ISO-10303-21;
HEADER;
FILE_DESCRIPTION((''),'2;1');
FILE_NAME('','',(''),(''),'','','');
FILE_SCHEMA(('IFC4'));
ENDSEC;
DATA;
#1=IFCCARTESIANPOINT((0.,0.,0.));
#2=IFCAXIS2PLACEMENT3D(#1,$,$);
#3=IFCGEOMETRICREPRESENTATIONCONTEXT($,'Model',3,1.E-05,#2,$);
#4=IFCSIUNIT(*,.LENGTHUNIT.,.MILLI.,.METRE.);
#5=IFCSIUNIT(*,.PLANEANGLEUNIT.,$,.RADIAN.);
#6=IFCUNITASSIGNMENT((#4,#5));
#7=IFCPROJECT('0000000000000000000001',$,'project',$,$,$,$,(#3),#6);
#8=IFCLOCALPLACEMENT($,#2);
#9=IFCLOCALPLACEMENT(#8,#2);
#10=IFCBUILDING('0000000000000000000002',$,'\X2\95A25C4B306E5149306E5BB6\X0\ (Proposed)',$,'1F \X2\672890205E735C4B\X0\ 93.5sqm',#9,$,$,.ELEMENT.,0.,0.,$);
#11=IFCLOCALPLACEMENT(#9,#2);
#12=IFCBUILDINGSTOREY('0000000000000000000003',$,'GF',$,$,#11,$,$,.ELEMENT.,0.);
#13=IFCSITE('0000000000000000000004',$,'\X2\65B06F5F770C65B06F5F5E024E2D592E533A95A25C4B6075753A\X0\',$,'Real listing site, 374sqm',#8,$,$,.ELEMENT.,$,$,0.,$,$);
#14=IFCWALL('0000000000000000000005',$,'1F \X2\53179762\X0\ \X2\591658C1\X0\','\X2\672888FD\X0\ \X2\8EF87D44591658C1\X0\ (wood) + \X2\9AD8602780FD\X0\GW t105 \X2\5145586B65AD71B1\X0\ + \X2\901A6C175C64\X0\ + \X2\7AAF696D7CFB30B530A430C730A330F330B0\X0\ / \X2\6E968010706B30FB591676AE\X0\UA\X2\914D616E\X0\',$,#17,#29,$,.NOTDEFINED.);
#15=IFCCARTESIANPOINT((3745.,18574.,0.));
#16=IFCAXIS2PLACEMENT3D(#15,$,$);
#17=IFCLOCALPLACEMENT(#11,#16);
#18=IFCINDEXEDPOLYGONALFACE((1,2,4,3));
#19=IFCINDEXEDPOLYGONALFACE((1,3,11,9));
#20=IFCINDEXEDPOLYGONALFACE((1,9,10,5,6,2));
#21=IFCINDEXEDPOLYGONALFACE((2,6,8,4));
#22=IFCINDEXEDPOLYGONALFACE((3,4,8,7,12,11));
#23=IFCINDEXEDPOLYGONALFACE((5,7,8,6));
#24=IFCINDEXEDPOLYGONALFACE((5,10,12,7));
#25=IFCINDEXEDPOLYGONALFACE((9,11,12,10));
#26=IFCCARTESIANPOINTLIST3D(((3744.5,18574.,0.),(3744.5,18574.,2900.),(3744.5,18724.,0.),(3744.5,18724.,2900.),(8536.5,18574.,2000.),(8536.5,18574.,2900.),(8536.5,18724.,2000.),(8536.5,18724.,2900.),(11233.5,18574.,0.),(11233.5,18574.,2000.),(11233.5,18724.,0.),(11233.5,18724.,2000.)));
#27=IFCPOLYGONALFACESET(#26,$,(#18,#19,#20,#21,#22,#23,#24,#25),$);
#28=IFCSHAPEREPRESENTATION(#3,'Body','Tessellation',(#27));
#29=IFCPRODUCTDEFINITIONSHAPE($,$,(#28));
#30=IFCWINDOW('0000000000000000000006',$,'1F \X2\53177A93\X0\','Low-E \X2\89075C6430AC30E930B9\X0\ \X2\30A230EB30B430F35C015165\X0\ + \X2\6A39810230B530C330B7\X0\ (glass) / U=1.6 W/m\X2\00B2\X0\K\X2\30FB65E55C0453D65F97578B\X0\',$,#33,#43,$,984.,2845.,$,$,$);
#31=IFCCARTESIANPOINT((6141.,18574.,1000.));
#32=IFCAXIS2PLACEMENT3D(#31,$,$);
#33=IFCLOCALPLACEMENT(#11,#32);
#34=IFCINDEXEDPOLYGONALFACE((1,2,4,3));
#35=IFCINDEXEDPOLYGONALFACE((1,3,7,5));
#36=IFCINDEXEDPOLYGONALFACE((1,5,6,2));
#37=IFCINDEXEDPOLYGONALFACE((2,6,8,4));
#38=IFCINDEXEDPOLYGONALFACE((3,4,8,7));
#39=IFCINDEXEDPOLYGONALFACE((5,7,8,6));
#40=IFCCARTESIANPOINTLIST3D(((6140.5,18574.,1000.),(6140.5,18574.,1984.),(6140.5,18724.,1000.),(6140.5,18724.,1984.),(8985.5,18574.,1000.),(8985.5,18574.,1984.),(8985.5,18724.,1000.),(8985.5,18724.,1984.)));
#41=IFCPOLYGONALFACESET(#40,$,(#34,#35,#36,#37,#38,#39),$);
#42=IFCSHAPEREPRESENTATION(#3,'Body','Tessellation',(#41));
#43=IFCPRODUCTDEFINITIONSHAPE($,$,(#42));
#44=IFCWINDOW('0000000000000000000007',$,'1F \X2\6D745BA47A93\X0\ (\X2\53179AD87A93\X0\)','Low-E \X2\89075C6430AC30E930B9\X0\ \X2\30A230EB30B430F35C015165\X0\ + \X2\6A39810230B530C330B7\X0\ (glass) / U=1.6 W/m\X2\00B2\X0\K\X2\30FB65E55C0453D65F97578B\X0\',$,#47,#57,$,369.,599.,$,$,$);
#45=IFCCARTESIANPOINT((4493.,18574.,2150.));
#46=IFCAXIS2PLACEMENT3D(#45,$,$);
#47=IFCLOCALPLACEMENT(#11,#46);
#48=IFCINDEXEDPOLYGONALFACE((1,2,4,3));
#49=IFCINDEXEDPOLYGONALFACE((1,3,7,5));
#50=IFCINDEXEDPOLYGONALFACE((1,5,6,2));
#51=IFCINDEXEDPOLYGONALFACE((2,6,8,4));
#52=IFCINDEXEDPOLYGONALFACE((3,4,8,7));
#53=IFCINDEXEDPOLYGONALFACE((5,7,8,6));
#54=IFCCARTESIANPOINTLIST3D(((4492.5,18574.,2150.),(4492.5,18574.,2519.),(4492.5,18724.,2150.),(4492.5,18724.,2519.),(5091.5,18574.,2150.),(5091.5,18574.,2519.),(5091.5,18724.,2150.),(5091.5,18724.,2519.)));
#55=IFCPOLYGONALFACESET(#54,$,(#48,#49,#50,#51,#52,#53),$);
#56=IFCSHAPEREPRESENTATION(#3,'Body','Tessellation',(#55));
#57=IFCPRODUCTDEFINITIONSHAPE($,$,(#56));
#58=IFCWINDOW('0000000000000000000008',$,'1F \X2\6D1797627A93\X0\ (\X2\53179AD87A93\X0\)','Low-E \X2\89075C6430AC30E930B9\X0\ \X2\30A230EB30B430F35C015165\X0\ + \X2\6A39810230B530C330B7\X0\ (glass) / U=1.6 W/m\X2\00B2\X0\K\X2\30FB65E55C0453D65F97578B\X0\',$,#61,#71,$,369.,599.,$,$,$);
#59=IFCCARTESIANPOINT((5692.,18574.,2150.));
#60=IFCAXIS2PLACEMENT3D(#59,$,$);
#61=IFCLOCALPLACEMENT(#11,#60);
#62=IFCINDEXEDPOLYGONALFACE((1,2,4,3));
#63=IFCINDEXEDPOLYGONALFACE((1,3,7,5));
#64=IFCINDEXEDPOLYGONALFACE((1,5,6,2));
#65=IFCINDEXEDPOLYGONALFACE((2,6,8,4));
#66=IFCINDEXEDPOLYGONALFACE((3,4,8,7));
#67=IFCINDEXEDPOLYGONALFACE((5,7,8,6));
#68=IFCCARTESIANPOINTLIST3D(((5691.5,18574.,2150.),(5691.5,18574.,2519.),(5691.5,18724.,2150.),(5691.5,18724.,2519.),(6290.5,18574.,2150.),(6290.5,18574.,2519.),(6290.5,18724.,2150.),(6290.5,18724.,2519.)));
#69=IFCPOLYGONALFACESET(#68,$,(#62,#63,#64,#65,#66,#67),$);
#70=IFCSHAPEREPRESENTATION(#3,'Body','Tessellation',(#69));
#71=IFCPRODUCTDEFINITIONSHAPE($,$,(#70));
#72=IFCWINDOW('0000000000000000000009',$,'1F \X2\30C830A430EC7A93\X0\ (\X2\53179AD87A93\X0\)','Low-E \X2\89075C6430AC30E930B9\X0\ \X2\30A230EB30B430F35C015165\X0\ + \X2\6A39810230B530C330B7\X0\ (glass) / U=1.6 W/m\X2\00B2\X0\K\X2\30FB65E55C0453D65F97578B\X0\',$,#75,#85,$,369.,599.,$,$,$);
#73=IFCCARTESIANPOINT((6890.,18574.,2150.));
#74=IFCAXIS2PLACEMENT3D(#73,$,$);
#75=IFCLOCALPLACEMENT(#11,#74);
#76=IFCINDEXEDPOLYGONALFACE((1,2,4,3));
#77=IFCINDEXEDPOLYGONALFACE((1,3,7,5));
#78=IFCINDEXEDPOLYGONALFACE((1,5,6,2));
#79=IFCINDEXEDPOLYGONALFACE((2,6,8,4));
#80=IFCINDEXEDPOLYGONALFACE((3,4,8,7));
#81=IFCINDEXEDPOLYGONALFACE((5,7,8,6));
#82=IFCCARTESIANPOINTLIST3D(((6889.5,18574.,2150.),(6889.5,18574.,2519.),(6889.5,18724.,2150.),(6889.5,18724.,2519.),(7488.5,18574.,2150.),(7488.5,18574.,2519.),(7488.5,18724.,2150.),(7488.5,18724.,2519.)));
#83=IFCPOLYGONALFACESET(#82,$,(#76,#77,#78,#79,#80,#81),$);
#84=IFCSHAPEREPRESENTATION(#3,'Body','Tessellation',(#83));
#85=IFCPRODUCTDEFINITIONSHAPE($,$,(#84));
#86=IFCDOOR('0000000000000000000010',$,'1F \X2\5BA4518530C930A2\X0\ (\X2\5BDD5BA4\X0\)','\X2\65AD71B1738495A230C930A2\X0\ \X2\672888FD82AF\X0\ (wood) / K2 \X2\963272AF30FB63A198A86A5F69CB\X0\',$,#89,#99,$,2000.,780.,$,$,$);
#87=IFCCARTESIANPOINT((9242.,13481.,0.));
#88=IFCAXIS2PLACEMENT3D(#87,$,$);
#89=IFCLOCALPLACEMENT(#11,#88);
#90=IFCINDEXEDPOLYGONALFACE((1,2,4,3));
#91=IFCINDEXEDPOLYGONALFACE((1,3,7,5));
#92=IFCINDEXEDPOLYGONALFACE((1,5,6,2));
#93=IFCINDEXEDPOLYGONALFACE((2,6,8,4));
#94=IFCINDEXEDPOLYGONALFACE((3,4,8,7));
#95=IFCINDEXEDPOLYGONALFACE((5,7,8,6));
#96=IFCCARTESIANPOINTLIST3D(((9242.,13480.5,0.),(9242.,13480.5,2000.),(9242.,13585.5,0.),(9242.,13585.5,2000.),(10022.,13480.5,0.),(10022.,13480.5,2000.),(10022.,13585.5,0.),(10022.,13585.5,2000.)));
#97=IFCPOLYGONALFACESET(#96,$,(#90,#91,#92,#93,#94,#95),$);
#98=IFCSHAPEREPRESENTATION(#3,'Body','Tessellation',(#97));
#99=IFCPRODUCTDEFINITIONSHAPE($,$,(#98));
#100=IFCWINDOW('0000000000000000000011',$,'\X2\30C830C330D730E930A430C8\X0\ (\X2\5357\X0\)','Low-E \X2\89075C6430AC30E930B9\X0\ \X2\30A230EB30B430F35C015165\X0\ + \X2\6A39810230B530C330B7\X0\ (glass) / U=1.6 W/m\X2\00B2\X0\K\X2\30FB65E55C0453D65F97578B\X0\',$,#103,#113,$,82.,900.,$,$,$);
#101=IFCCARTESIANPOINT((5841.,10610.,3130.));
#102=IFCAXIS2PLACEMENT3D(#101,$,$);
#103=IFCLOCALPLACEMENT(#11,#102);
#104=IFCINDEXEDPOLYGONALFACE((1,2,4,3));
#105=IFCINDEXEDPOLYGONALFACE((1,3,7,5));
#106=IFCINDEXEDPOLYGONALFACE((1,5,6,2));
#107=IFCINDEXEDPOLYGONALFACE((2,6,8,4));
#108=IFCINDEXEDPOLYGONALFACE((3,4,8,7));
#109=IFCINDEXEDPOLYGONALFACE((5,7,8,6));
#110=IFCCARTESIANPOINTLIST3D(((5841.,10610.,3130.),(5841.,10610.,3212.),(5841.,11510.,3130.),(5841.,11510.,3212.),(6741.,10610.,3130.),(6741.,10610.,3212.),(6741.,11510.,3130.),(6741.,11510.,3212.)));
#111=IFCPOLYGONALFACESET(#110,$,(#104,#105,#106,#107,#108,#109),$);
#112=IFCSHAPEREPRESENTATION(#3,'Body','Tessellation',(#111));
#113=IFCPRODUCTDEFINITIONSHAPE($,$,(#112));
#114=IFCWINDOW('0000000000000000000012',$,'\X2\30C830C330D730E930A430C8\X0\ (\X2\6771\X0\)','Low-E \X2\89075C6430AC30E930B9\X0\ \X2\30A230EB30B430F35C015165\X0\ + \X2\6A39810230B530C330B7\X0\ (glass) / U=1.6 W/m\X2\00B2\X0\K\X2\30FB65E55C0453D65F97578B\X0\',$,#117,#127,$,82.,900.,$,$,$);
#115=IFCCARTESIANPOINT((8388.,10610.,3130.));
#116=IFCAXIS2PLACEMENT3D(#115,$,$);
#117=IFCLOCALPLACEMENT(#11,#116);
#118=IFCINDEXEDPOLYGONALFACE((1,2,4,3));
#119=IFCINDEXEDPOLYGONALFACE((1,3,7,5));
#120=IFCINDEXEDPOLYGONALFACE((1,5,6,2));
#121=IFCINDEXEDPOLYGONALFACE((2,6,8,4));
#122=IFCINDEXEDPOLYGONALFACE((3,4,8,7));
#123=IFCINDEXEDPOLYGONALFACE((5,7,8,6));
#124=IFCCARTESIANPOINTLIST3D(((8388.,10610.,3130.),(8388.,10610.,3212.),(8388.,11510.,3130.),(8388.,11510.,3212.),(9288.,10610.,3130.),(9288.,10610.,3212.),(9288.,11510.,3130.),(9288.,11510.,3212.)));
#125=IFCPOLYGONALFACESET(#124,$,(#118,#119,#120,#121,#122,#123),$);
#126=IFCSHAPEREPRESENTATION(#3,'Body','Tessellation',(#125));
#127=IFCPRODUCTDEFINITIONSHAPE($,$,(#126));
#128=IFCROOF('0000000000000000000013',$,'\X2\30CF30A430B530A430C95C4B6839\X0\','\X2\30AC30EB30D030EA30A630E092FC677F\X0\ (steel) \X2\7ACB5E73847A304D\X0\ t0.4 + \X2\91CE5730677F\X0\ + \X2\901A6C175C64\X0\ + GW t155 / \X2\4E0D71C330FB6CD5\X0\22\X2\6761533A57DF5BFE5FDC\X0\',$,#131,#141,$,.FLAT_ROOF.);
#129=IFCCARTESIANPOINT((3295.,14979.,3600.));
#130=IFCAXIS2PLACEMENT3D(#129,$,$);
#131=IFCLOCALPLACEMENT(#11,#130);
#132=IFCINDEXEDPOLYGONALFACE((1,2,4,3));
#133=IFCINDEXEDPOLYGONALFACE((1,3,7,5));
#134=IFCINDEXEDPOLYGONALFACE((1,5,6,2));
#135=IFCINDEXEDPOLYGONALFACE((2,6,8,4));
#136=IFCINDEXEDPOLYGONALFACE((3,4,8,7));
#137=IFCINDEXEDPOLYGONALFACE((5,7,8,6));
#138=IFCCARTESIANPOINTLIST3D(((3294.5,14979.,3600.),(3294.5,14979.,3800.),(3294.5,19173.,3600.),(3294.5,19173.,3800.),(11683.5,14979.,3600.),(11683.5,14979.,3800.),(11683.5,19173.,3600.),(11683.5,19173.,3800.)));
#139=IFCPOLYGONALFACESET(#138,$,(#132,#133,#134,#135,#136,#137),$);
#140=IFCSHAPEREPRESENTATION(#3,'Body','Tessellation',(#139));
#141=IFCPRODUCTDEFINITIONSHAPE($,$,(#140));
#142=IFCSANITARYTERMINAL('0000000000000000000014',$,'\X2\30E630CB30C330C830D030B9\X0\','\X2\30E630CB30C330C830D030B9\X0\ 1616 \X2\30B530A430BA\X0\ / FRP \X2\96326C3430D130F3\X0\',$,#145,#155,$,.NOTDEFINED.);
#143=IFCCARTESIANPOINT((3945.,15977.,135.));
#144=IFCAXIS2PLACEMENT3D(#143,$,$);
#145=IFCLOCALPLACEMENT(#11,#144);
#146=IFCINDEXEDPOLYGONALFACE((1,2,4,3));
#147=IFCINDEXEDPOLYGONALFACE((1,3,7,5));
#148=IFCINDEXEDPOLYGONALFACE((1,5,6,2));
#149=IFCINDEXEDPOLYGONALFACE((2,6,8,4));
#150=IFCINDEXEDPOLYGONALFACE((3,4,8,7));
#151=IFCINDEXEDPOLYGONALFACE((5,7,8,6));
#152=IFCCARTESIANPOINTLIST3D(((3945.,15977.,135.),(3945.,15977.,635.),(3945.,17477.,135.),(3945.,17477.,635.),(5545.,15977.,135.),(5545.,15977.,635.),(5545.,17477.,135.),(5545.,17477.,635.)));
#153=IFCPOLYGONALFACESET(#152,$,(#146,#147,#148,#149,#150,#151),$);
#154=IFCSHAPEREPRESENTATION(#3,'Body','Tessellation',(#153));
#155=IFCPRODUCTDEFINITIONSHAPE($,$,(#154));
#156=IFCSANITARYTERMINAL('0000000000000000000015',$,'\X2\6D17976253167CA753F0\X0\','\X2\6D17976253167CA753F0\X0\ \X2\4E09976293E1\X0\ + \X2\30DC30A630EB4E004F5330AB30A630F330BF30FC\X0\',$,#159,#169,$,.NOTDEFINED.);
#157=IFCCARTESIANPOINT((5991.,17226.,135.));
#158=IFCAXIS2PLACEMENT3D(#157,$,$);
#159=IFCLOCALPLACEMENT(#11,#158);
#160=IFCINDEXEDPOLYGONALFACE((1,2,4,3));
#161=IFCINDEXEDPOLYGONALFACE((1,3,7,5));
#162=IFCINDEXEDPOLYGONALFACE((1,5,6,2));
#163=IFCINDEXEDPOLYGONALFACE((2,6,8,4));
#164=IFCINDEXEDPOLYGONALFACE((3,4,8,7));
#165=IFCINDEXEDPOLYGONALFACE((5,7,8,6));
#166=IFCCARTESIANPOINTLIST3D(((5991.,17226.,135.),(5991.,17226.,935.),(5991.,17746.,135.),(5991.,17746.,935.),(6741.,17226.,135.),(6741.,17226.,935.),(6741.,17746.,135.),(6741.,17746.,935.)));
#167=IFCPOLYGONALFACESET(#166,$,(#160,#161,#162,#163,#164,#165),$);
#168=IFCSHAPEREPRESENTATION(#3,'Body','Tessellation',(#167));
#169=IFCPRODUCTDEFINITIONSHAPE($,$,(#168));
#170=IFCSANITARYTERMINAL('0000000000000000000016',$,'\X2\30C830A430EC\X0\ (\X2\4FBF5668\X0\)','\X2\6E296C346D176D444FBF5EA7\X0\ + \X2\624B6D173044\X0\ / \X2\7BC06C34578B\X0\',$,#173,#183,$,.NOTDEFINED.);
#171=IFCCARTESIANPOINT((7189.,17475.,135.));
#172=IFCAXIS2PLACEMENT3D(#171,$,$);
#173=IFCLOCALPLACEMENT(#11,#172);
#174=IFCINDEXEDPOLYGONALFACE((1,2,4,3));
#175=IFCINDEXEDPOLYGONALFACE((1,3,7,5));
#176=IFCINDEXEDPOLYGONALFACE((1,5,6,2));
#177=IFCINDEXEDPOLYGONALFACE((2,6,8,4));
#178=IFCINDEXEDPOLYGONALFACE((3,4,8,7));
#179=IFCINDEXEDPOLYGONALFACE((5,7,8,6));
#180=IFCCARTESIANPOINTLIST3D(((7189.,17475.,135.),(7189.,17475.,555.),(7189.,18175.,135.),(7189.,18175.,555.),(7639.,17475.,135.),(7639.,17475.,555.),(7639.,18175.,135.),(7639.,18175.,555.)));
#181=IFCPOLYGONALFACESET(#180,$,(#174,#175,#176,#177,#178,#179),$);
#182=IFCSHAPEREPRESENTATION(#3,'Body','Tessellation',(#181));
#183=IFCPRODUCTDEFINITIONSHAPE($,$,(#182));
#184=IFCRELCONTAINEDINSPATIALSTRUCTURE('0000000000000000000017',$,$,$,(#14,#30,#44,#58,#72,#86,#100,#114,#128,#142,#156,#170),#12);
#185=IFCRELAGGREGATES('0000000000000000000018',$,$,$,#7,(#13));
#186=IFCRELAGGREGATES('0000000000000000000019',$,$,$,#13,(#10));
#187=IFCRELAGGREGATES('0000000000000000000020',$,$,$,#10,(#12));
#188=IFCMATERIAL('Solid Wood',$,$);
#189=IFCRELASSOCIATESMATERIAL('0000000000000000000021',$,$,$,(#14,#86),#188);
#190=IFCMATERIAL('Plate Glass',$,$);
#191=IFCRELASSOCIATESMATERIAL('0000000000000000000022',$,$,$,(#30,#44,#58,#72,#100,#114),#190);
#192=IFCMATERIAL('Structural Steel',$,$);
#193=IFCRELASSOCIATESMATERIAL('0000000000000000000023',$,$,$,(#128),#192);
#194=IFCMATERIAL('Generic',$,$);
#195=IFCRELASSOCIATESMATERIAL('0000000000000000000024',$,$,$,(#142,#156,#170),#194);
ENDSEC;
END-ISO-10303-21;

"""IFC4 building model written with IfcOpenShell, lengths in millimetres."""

from ifc_helpers import new_model, si_unit, frame, frame_2d, origin, place, context, project, spatial, rectangle, extrude, material, element, fill, save


model = new_model("IFC4")

# Units and contexts
model_context = context("Model", 3, precision=1e-05, world=origin())
ifc_project = project(units=[si_unit("LENGTHUNIT", "METRE", prefix="MILLI"), si_unit("PLANEANGLEUNIT", "RADIAN")], contexts=[model_context])

# Site, building, storey
site_placement = place(None, origin())
site = spatial("IfcSite", under=ifc_project, at=site_placement, Name="新潟県新潟市中央区関屋恵町", ObjectType="Real listing site, 374sqm", CompositionType="ELEMENT", RefElevation=0.0)
building_placement = place(site_placement, origin())
building = spatial("IfcBuilding", under=site, at=building_placement, Name="関屋の光の家 (Proposed)", ObjectType="1F 木造平屋 93.5sqm", CompositionType="ELEMENT", ElevationOfRefHeight=0.0, ElevationOfTerrain=0.0)
storey_placement = place(building_placement, origin())
storey = spatial("IfcBuildingStorey", under=building, at=storey_placement, Name="GF", CompositionType="ELEMENT", Elevation=0.0)

# Shared definitions
ifc_material_1 = material(Name="Solid Wood")

# Wall, openings, windows
wall_1_placement = place(storey_placement, frame((3745.0, 18574.0, 0.0)))
wall_1 = element("IfcWall", 1, at=wall_1_placement, inside=storey, material=ifc_material_1, Name="1F 北面 外壁", Description="木製 軸組外壁 (wood) + 高性能GW t105 充填断熱 + 通気層 + 窯業系サイディング / 準耐火・外皮UA配慮", PredefinedType="NOTDEFINED", context=model_context, shape_type="SweptSolid", body=[
    extrude(rectangle(XDim=7489.0, YDim=150.0, at=frame_2d((3744.0, 75.0))), frame((3745.0, 18574.0, 0.0)), (0.0, 0.0, 1.0), 2900.0),
])
opening_1_placement = place(storey_placement, frame((6141.0, 18574.0, 1000.0)))
opening_1 = element("IfcOpeningElement", 2, at=opening_1_placement, cuts=wall_1, PredefinedType="NOTDEFINED", context=model_context, shape_type="SweptSolid", body=[
    extrude(rectangle(XDim=2845.0, YDim=150.0, at=frame_2d((1422.0, 75.0))), frame((6141.0, 18574.0, 1000.0)), (0.0, 0.0, 1.0), 984.0),
])
opening_2_placement = place(storey_placement, frame((4493.0, 18574.0, 2150.0)))
opening_2 = element("IfcOpeningElement", 3, at=opening_2_placement, cuts=wall_1, PredefinedType="NOTDEFINED", context=model_context, shape_type="SweptSolid", body=[
    extrude(rectangle(XDim=599.0, YDim=150.0, at=frame_2d((299.0, 75.0))), frame((4493.0, 18574.0, 2150.0)), (0.0, 0.0, 1.0), 369.0),
])
opening_3_placement = place(storey_placement, frame((5692.0, 18574.0, 2150.0)))
opening_3 = element("IfcOpeningElement", 4, at=opening_3_placement, cuts=wall_1, PredefinedType="NOTDEFINED", context=model_context, shape_type="SweptSolid", body=[
    extrude(rectangle(XDim=599.0, YDim=150.0, at=frame_2d((299.0, 75.0))), frame((5692.0, 18574.0, 2150.0)), (0.0, 0.0, 1.0), 369.0),
])
opening_4_placement = place(storey_placement, frame((6890.0, 18574.0, 2150.0)))
opening_4 = element("IfcOpeningElement", 5, at=opening_4_placement, cuts=wall_1, PredefinedType="NOTDEFINED", context=model_context, shape_type="SweptSolid", body=[
    extrude(rectangle(XDim=599.0, YDim=150.0, at=frame_2d((299.0, 75.0))), frame((6890.0, 18574.0, 2150.0)), (0.0, 0.0, 1.0), 369.0),
])
ifc_material_2 = material(Name="Plate Glass")
window_1_placement = place(storey_placement, frame((6141.0, 18574.0, 1000.0)))
window_1 = element("IfcWindow", 6, at=window_1_placement, inside=storey, material=ifc_material_2, Name="1F 北窓", Description="Low-E 複層ガラス アルゴン封入 + 樹脂サッシ (glass) / U=1.6 W/m²K・日射取得型", OverallHeight=984.0, OverallWidth=2845.0, context=model_context, shape_type="SweptSolid", body=[
    extrude(rectangle(XDim=2845.0, YDim=150.0, at=frame_2d((1422.0, 75.0))), frame((6141.0, 18574.0, 1000.0)), (0.0, 0.0, 1.0), 984.0),
])
fill(opening_1, window_1)
window_2_placement = place(storey_placement, frame((4493.0, 18574.0, 2150.0)))
window_2 = element("IfcWindow", 7, at=window_2_placement, inside=storey, material=ifc_material_2, Name="1F 浴室窓 (北高窓)", Description="Low-E 複層ガラス アルゴン封入 + 樹脂サッシ (glass) / U=1.6 W/m²K・日射取得型", OverallHeight=369.0, OverallWidth=599.0, context=model_context, shape_type="SweptSolid", body=[
    extrude(rectangle(XDim=599.0, YDim=150.0, at=frame_2d((299.0, 75.0))), frame((4493.0, 18574.0, 2150.0)), (0.0, 0.0, 1.0), 369.0),
])
fill(opening_2, window_2)
window_3_placement = place(storey_placement, frame((5692.0, 18574.0, 2150.0)))
window_3 = element("IfcWindow", 8, at=window_3_placement, inside=storey, material=ifc_material_2, Name="1F 洗面窓 (北高窓)", Description="Low-E 複層ガラス アルゴン封入 + 樹脂サッシ (glass) / U=1.6 W/m²K・日射取得型", OverallHeight=369.0, OverallWidth=599.0, context=model_context, shape_type="SweptSolid", body=[
    extrude(rectangle(XDim=599.0, YDim=150.0, at=frame_2d((299.0, 75.0))), frame((5692.0, 18574.0, 2150.0)), (0.0, 0.0, 1.0), 369.0),
])
fill(opening_3, window_3)
window_4_placement = place(storey_placement, frame((6890.0, 18574.0, 2150.0)))
window_4 = element("IfcWindow", 9, at=window_4_placement, inside=storey, material=ifc_material_2, Name="1F トイレ窓 (北高窓)", Description="Low-E 複層ガラス アルゴン封入 + 樹脂サッシ (glass) / U=1.6 W/m²K・日射取得型", OverallHeight=369.0, OverallWidth=599.0, context=model_context, shape_type="SweptSolid", body=[
    extrude(rectangle(XDim=599.0, YDim=150.0, at=frame_2d((299.0, 75.0))), frame((6890.0, 18574.0, 2150.0)), (0.0, 0.0, 1.0), 369.0),
])
fill(opening_4, window_4)

# Door
door_1_placement = place(storey_placement, frame((9242.0, 13481.0, 0.0)))
element("IfcDoor", 10, at=door_1_placement, inside=storey, material=ifc_material_1, Name="1F 室内ドア (寝室)", Description="断熱玄関ドア 木製芯 (wood) / K2 防犯・採風機構", OverallHeight=2000.0, OverallWidth=780.0, context=model_context, shape_type="SweptSolid", body=[
    extrude(rectangle(XDim=780.0, YDim=105.0, at=frame_2d((390.0, 52.0))), frame((9242.0, 13481.0, 0.0)), (0.0, 0.0, 1.0), 2000.0),
])

# Windows
window_5_placement = place(storey_placement, frame((5841.0, 10610.0, 3130.0)))
element("IfcWindow", 11, at=window_5_placement, inside=storey, material=ifc_material_2, Name="トップライト (南)", Description="Low-E 複層ガラス アルゴン封入 + 樹脂サッシ (glass) / U=1.6 W/m²K・日射取得型", OverallHeight=82.0, OverallWidth=900.0, context=model_context, shape_type="SweptSolid", body=[
    extrude(rectangle(XDim=900.0, YDim=900.0, at=frame_2d((450.0, 450.0))), frame((5841.0, 10610.0, 3130.0)), (0.0, 0.0, 1.0), 82.0),
])
window_6_placement = place(storey_placement, frame((8388.0, 10610.0, 3130.0)))
element("IfcWindow", 12, at=window_6_placement, inside=storey, material=ifc_material_2, Name="トップライト (東)", Description="Low-E 複層ガラス アルゴン封入 + 樹脂サッシ (glass) / U=1.6 W/m²K・日射取得型", OverallHeight=82.0, OverallWidth=900.0, context=model_context, shape_type="SweptSolid", body=[
    extrude(rectangle(XDim=900.0, YDim=900.0, at=frame_2d((450.0, 450.0))), frame((8388.0, 10610.0, 3130.0)), (0.0, 0.0, 1.0), 82.0),
])

# Roof
ifc_material_3 = material(Name="Structural Steel")
roof_placement = place(storey_placement, frame((3295.0, 14979.0, 3600.0)))
element("IfcRoof", 13, at=roof_placement, inside=storey, material=ifc_material_3, Name="ハイサイド屋根", Description="ガルバリウム鋼板 (steel) 立平葺き t0.4 + 野地板 + 通気層 + GW t155 / 不燃・法22条区域対応", PredefinedType="FLAT_ROOF", context=model_context, shape_type="SweptSolid", body=[
    extrude(rectangle(XDim=8389.0, YDim=4194.0, at=frame_2d((4194.0, 2097.0))), frame((3295.0, 14979.0, 3600.0)), (0.0, 0.0, 1.0), 200.0),
])

# Sanitary terminals
ifc_material_4 = material(Name="Generic")
sanitary_terminal_1_placement = place(storey_placement, frame((3945.0, 15977.0, 135.0)))
element("IfcSanitaryTerminal", 14, at=sanitary_terminal_1_placement, inside=storey, material=ifc_material_4, Name="ユニットバス", Description="ユニットバス 1616 サイズ / FRP 防水パン", PredefinedType="NOTDEFINED", context=model_context, shape_type="SweptSolid", body=[
    extrude(rectangle(XDim=1600.0, YDim=1500.0, at=frame_2d((800.0, 750.0))), frame((3945.0, 15977.0, 135.0)), (0.0, 0.0, 1.0), 500.0),
])
sanitary_terminal_2_placement = place(storey_placement, frame((5991.0, 17226.0, 135.0)))
element("IfcSanitaryTerminal", 15, at=sanitary_terminal_2_placement, inside=storey, material=ifc_material_4, Name="洗面化粧台", Description="洗面化粧台 三面鏡 + ボウル一体カウンター", PredefinedType="NOTDEFINED", context=model_context, shape_type="SweptSolid", body=[
    extrude(rectangle(XDim=750.0, YDim=520.0, at=frame_2d((375.0, 260.0))), frame((5991.0, 17226.0, 135.0)), (0.0, 0.0, 1.0), 800.0),
])
sanitary_terminal_3_placement = place(storey_placement, frame((7189.0, 17475.0, 135.0)))
element("IfcSanitaryTerminal", 16, at=sanitary_terminal_3_placement, inside=storey, material=ifc_material_4, Name="トイレ (便器)", Description="温水洗浄便座 + 手洗い / 節水型", PredefinedType="NOTDEFINED", context=model_context, shape_type="SweptSolid", body=[
    extrude(rectangle(XDim=450.0, YDim=700.0, at=frame_2d((225.0, 350.0))), frame((7189.0, 17475.0, 135.0)), (0.0, 0.0, 1.0), 420.0),
])

save(model, "model.ifc")
